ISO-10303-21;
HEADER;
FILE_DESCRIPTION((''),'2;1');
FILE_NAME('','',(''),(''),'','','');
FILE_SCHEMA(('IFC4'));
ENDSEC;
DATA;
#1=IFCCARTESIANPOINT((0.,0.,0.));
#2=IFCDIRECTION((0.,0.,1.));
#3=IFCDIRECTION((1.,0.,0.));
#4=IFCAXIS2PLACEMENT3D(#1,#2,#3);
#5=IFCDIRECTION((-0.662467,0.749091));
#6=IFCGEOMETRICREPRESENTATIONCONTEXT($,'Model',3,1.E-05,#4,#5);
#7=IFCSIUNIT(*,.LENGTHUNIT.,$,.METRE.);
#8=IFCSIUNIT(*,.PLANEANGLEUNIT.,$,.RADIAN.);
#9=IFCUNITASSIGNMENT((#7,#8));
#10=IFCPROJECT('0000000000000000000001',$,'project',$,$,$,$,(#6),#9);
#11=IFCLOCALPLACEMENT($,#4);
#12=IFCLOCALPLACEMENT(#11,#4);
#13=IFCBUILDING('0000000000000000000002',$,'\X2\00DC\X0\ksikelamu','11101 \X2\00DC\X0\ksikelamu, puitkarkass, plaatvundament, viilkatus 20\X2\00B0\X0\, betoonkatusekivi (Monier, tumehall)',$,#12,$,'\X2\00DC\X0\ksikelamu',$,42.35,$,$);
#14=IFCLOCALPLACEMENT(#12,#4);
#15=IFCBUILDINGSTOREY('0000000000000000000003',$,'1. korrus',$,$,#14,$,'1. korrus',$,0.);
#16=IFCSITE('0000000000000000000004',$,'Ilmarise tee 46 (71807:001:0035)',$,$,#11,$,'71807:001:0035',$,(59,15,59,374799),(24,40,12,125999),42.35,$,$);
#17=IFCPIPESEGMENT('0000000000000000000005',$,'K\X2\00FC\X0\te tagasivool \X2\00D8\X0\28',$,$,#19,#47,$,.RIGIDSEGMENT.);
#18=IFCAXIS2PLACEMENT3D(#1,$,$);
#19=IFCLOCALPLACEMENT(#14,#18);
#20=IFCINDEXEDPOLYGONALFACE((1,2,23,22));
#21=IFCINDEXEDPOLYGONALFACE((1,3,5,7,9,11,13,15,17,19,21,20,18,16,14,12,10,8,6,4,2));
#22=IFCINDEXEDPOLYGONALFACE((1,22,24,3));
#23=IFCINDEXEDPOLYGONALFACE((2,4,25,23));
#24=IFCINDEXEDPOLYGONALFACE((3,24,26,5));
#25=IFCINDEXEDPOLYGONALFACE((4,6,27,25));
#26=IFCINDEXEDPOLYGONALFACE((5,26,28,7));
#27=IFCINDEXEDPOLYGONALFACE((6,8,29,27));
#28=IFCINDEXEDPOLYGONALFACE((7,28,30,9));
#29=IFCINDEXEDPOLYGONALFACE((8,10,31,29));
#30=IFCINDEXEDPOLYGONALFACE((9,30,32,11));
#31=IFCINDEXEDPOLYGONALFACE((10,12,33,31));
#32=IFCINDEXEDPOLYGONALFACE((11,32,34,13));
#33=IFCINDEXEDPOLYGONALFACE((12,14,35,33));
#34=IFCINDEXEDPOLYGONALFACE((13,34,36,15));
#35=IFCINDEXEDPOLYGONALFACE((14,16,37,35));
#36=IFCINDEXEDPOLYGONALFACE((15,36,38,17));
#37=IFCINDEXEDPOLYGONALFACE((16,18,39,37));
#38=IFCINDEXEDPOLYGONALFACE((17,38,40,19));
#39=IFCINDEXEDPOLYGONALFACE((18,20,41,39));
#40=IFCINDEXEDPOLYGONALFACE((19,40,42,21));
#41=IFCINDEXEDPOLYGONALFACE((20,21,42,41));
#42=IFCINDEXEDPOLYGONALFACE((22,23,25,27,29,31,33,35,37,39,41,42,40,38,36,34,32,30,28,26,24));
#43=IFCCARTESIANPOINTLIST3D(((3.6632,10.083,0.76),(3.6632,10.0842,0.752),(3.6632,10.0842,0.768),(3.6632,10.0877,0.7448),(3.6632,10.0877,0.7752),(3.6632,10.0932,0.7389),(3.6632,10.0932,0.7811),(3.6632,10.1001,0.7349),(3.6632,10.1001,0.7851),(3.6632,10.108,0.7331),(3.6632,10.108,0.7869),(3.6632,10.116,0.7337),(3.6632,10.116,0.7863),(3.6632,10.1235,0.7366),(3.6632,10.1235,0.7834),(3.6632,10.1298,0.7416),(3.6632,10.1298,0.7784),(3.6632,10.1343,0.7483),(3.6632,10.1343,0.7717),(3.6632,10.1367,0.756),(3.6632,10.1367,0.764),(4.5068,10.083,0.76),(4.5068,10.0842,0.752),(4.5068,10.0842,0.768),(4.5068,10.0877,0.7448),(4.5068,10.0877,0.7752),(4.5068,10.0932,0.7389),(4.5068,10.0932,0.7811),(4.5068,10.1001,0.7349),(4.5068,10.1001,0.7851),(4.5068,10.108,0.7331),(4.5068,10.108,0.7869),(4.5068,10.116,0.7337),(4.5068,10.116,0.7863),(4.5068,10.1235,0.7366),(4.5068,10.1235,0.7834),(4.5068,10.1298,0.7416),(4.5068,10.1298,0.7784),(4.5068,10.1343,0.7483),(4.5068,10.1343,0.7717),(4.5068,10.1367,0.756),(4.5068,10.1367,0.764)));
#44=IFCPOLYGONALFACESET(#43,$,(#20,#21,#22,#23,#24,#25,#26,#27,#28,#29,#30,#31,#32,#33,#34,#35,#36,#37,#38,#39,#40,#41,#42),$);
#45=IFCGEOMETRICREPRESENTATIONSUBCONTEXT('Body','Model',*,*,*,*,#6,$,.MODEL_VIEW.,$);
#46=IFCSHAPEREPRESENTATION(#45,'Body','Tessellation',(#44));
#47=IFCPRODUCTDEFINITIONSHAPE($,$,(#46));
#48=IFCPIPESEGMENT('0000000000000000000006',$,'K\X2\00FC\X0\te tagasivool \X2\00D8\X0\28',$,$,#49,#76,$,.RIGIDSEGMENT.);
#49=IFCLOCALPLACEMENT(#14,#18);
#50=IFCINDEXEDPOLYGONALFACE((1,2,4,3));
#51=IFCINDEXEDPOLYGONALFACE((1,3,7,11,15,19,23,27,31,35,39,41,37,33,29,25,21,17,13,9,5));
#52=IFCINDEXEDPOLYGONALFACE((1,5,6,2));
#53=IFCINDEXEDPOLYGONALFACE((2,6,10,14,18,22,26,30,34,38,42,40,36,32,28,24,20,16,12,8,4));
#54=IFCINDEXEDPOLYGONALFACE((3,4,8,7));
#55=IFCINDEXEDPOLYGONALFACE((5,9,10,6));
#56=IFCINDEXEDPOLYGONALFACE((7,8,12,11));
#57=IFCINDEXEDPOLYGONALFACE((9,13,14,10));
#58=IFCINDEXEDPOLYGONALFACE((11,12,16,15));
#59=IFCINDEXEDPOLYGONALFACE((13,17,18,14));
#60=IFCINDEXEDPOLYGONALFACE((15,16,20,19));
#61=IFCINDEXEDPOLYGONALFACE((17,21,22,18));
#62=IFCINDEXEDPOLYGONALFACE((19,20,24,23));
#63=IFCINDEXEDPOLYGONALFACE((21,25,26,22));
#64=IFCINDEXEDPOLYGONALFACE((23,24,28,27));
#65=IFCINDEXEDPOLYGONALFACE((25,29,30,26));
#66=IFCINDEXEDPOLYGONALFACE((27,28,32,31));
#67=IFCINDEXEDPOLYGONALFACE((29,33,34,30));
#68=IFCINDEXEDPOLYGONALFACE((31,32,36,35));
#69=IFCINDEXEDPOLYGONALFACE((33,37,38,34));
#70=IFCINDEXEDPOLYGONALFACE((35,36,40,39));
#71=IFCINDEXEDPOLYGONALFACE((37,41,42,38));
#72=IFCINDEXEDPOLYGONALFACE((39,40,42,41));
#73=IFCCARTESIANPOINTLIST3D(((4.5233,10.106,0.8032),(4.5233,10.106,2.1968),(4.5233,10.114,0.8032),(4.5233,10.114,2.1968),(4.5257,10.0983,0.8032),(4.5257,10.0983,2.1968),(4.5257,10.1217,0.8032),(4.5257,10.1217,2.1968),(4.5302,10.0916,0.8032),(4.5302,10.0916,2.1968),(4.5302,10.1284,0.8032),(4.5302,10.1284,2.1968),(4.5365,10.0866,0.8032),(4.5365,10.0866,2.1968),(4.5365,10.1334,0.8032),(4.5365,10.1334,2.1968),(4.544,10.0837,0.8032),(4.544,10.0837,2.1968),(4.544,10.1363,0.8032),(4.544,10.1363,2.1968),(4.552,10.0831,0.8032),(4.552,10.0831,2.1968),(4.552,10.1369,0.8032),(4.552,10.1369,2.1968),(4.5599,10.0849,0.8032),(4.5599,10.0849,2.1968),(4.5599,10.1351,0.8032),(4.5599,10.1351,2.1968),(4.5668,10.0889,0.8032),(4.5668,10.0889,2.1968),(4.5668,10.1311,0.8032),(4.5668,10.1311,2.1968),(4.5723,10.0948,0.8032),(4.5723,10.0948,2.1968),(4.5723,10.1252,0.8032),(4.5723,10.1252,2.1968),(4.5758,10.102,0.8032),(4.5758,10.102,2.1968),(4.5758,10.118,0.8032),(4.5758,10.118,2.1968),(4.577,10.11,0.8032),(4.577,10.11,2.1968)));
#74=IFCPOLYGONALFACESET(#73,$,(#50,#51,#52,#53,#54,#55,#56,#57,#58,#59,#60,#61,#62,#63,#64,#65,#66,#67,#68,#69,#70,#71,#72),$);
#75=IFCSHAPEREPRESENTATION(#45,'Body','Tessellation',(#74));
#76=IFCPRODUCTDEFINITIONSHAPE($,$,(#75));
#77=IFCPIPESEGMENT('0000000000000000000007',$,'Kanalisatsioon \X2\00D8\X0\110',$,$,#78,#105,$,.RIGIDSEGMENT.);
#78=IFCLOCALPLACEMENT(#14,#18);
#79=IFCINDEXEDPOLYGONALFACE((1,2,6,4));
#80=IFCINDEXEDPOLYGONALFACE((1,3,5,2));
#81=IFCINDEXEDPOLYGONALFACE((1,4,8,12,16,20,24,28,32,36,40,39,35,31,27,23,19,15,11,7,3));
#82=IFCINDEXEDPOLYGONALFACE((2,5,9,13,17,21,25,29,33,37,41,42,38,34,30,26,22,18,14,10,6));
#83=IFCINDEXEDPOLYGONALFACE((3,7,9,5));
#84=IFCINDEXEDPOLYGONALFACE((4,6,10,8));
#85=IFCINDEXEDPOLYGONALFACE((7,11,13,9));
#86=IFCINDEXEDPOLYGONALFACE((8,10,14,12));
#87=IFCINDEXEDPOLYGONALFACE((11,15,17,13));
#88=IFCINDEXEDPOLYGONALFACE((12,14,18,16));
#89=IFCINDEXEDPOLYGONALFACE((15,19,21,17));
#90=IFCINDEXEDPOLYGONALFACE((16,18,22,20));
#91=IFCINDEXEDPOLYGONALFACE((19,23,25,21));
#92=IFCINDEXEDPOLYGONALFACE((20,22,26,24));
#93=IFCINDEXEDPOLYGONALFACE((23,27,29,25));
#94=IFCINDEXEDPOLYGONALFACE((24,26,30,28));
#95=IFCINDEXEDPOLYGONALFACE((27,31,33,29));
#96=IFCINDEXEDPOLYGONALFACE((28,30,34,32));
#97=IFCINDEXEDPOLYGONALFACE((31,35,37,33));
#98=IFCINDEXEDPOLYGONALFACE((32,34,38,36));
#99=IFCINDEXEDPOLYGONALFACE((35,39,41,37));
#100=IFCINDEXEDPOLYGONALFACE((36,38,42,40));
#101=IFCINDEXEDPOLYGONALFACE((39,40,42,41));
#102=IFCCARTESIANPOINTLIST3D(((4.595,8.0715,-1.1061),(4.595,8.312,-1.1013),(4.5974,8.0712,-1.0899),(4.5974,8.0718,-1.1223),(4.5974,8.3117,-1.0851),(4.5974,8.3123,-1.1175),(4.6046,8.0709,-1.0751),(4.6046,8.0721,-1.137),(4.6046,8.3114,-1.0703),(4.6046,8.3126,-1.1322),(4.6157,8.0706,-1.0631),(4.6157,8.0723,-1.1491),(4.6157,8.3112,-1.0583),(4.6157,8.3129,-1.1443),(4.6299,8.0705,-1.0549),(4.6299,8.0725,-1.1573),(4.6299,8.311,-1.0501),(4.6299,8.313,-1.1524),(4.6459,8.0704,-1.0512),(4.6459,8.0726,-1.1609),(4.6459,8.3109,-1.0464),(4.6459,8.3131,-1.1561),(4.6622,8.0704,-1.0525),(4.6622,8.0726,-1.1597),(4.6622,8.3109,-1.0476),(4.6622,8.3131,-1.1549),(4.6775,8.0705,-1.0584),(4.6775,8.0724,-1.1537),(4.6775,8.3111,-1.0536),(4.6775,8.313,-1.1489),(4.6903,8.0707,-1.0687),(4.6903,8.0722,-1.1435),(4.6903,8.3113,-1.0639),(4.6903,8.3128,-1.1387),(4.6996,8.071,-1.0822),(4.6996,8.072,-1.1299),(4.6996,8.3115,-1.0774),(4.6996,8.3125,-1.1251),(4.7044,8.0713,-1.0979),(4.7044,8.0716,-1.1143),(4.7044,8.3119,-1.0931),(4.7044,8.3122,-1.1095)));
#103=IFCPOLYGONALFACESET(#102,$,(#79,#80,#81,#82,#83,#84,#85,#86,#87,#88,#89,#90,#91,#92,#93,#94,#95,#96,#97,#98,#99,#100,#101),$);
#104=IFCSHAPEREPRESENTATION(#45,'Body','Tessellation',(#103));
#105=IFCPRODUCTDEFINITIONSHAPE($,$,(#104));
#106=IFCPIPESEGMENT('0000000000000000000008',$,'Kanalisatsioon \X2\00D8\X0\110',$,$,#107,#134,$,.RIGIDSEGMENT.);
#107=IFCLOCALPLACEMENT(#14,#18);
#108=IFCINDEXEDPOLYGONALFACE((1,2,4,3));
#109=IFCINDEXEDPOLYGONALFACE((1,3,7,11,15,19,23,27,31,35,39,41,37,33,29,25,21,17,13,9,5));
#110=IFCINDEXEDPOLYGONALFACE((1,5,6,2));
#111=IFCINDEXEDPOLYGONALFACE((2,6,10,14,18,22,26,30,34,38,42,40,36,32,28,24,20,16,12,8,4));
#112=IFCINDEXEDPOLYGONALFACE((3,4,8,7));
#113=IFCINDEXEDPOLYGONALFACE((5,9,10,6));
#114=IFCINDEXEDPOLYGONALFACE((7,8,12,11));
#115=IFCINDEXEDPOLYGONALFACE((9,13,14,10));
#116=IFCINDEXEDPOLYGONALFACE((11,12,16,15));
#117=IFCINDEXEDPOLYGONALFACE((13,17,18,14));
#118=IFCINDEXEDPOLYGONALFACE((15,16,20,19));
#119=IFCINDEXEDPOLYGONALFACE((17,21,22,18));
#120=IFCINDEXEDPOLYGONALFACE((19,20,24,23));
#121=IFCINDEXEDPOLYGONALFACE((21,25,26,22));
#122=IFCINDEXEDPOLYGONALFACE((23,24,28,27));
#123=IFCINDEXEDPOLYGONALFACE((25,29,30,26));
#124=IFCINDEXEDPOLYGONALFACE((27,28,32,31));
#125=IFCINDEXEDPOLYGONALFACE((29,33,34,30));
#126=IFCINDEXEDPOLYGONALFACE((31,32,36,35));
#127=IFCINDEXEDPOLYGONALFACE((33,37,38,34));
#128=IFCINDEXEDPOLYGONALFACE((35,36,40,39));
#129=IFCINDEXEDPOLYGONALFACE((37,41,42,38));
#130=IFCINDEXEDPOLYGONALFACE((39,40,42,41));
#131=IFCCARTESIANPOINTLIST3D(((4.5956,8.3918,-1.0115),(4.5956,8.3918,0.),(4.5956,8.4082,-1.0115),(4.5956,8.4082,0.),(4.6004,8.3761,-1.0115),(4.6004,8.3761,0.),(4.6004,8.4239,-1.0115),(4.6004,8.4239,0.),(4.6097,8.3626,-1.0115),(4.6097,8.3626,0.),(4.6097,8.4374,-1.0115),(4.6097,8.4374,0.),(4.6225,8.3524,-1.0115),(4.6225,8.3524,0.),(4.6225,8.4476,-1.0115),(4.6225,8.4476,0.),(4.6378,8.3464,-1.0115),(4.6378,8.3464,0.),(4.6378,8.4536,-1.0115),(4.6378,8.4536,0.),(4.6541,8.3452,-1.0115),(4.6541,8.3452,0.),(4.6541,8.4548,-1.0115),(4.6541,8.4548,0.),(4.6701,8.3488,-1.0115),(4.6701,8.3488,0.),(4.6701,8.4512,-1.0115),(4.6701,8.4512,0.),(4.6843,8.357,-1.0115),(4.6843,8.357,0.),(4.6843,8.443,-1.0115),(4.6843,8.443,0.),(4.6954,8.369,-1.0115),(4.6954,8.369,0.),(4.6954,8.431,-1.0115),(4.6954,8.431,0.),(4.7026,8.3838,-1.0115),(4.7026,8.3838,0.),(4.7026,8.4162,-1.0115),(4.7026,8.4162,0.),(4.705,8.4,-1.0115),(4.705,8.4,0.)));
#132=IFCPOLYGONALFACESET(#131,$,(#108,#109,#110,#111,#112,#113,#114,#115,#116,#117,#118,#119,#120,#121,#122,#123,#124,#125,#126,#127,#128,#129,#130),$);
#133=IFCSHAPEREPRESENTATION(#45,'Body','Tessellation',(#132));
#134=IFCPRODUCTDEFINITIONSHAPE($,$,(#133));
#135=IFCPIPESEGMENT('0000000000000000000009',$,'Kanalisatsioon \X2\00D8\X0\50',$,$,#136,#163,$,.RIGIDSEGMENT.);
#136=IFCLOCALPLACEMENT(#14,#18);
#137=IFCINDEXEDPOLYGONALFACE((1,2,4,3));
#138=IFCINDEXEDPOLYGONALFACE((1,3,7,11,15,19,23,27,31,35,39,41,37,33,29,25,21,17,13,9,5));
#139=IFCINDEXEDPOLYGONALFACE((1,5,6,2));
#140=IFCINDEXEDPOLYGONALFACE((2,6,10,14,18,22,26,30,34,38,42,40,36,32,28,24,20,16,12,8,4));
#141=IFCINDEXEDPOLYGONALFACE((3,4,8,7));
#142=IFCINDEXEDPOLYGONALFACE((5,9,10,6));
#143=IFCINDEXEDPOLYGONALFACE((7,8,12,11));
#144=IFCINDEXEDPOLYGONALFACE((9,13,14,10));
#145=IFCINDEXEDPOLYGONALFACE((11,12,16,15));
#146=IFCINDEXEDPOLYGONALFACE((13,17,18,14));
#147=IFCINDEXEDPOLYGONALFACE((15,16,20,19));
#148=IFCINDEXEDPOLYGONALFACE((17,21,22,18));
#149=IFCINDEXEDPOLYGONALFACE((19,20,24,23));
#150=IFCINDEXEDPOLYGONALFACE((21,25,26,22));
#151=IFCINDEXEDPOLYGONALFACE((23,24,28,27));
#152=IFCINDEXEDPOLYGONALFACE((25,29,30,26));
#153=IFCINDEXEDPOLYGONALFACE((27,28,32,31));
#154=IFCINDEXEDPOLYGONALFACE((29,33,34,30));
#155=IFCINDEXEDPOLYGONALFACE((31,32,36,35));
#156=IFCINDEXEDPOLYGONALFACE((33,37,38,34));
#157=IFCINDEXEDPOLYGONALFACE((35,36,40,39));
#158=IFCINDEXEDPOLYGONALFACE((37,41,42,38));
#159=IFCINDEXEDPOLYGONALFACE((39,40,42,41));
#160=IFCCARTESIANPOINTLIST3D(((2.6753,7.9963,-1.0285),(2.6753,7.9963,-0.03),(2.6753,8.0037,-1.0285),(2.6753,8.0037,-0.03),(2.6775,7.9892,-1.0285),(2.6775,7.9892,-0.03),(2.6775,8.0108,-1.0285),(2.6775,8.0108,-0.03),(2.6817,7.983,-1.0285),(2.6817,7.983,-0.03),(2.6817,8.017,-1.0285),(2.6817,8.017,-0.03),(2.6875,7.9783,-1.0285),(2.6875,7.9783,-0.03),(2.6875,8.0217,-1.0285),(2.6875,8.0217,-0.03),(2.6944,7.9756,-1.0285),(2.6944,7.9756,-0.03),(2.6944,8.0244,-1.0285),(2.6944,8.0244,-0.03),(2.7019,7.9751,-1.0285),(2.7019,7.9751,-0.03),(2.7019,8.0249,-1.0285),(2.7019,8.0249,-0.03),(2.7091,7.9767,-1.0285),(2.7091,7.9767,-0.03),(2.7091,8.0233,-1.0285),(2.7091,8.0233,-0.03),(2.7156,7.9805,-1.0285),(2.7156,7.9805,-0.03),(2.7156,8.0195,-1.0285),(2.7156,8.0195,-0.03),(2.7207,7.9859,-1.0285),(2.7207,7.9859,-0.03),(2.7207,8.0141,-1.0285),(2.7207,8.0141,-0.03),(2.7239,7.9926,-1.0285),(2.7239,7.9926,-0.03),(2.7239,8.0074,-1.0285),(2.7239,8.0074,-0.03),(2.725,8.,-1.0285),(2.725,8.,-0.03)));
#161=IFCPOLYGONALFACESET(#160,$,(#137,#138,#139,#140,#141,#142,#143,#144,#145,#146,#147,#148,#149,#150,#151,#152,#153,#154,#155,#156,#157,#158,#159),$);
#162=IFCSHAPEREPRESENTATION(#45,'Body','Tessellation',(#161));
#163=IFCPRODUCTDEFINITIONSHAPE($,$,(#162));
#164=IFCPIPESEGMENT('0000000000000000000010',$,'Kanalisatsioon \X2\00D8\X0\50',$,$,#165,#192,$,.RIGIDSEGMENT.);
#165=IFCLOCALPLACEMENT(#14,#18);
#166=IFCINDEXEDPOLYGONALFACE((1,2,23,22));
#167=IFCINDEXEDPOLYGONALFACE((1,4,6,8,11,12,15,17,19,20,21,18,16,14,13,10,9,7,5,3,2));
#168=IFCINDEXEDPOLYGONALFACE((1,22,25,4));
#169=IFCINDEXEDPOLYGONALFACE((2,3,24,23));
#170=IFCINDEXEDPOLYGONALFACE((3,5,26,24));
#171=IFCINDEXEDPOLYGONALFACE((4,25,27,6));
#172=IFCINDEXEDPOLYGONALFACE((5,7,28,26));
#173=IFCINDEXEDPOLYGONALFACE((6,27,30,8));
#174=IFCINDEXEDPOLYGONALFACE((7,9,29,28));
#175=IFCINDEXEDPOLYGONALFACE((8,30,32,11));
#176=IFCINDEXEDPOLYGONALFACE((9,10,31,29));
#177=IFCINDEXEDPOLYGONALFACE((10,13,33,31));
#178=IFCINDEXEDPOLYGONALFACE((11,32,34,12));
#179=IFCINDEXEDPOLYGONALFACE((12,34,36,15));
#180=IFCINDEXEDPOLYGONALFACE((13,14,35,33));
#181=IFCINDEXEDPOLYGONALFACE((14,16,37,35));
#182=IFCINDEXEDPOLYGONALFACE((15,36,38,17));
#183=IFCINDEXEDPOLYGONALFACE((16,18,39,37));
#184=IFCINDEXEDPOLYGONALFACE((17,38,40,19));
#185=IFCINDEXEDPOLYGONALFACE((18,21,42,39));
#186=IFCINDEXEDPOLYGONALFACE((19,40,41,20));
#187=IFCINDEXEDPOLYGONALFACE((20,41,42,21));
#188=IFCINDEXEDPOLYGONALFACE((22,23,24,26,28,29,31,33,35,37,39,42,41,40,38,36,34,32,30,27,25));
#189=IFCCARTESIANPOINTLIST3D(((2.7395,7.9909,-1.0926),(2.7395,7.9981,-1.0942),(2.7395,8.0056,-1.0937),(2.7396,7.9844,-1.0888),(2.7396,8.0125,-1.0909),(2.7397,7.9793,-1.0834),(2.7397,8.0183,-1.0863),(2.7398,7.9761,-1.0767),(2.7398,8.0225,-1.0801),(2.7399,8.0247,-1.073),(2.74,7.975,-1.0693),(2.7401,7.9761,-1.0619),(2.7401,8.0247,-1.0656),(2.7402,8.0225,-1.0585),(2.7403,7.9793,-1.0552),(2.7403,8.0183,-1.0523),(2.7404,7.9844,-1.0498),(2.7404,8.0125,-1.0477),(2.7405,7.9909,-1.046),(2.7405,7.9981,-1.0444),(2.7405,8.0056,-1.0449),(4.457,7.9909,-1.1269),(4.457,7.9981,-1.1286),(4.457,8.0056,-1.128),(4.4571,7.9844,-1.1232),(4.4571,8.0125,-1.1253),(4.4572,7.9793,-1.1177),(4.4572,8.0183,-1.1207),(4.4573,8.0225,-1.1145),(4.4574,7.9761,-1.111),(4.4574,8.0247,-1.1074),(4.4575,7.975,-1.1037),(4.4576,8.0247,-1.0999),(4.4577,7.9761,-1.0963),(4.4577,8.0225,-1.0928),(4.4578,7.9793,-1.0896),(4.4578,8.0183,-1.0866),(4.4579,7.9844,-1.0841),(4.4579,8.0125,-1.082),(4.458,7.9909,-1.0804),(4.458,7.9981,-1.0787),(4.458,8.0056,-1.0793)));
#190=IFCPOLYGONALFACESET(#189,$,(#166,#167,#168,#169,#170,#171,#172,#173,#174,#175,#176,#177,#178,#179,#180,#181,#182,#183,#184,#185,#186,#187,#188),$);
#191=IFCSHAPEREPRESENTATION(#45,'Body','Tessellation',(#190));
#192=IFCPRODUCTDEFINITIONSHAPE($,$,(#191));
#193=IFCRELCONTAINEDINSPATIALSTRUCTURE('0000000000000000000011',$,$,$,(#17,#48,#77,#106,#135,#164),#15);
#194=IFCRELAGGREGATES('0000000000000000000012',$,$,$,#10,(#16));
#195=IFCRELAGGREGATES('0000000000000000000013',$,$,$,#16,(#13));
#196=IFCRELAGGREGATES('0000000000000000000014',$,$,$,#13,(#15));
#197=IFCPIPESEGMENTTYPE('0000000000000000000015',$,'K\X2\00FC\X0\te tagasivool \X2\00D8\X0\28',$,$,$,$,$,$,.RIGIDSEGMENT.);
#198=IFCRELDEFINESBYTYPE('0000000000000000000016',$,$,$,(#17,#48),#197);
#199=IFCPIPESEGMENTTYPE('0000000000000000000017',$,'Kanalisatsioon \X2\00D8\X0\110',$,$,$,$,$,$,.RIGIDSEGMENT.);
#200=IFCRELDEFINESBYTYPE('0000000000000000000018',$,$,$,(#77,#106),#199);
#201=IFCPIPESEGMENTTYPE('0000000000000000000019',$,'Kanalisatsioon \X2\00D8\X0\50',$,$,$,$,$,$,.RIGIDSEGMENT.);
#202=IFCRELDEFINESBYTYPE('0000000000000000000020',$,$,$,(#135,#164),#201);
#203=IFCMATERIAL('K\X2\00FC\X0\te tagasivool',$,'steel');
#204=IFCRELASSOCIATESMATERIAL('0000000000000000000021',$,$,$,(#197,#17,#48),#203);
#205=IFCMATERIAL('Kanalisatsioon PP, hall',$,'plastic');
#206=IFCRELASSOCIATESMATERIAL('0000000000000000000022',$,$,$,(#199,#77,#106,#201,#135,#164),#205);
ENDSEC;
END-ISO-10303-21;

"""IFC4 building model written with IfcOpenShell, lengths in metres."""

from ifc_helpers import new_model, si_unit, direction, frame, origin_with_axes, place, context, subcontext, project, spatial, circle, extrude, material, type_object, element, save


model = new_model("IFC4")

# Units and contexts
model_context = context("Model", 3, precision=1e-05, world=origin_with_axes(), true_north=direction((-0.662467, 0.749091)))
body_context = subcontext(model_context, "Body", "Model", "MODEL_VIEW")
ifc_project = project(units=[si_unit("LENGTHUNIT", "METRE"), si_unit("PLANEANGLEUNIT", "RADIAN")], contexts=[model_context])

# Site, building, storey
site_placement = place(None, origin_with_axes())
site = spatial("IfcSite", under=ifc_project, at=site_placement, Name="Ilmarise tee 46 (71807:001:0035)", LongName="71807:001:0035", RefLatitude=(59, 15, 59, 374799), RefLongitude=(24, 40, 12, 125999), RefElevation=42.35)
building_placement = place(site_placement, origin_with_axes())
building = spatial("IfcBuilding", under=site, at=building_placement, Name="Üksikelamu", Description="11101 Üksikelamu, puitkarkass, plaatvundament, viilkatus 20°, betoonkatusekivi (Monier, tumehall)", LongName="Üksikelamu", ElevationOfRefHeight=42.35)
storey_placement = place(building_placement, origin_with_axes())
storey = spatial("IfcBuildingStorey", under=building, at=storey_placement, Name="1. korrus", LongName="1. korrus", Elevation=0.0)

# Shared definitions
ifc_material_1 = material(Name="Küte tagasivool", Category="steel")
ifc_material_2 = material(Name="Kanalisatsioon PP, hall", Category="plastic")

# Pipe segments
pipe_segment_type_1 = type_object("IfcPipeSegmentType", Name="Küte tagasivool Ø28", PredefinedType="RIGIDSEGMENT", material=ifc_material_1)
pipe_segment_1_placement = place(storey_placement, frame((3.6632, 10.11, 0.76), z_axis=(1.0, 0.0, 0.0), x_axis=(0.0, -1.0, 0.0)))
element("IfcPipeSegment", 1, at=pipe_segment_1_placement, inside=storey, type_object=pipe_segment_type_1, material=ifc_material_1, Name="Küte tagasivool Ø28", PredefinedType="RIGIDSEGMENT", context=body_context, shape_type="SweptSolid", body=[
    extrude(circle(Radius=0.027), origin_with_axes(), (0.0, 0.0, 1.0), 0.8436),
])
pipe_segment_2_placement = place(storey_placement, frame((4.55, 10.11, 0.8032), z_axis=(0.0, 0.0, 1.0), x_axis=(1.0, 0.0, 0.0)))
element("IfcPipeSegment", 2, at=pipe_segment_2_placement, inside=storey, type_object=pipe_segment_type_1, material=ifc_material_1, Name="Küte tagasivool Ø28", PredefinedType="RIGIDSEGMENT", context=body_context, shape_type="SweptSolid", body=[
    extrude(circle(Radius=0.027), origin_with_axes(), (0.0, 0.0, 1.0), 1.3936),
])
pipe_segment_type_2 = type_object("IfcPipeSegmentType", Name="Kanalisatsioon Ø110", PredefinedType="RIGIDSEGMENT", material=ifc_material_2)
pipe_segment_3_placement = place(storey_placement, frame((4.65, 8.312, -1.1013), z_axis=(0.0, -0.9998, -0.019996), x_axis=(-1.0, 0.0, 0.0)))
element("IfcPipeSegment", 3, at=pipe_segment_3_placement, inside=storey, type_object=pipe_segment_type_2, material=ifc_material_2, Name="Kanalisatsioon Ø110", PredefinedType="RIGIDSEGMENT", context=body_context, shape_type="SweptSolid", body=[
    extrude(circle(Radius=0.055), origin_with_axes(), (0.0, 0.0, 1.0), 0.2406),
])
pipe_segment_4_placement = place(storey_placement, frame((4.65, 8.4, 0.0), z_axis=(0.0, 0.0, -1.0), x_axis=(1.0, 0.0, 0.0)))
element("IfcPipeSegment", 4, at=pipe_segment_4_placement, inside=storey, type_object=pipe_segment_type_2, material=ifc_material_2, Name="Kanalisatsioon Ø110", PredefinedType="RIGIDSEGMENT", context=body_context, shape_type="SweptSolid", body=[
    extrude(circle(Radius=0.055), origin_with_axes(), (0.0, 0.0, 1.0), 1.0115),
])
pipe_segment_type_3 = type_object("IfcPipeSegmentType", Name="Kanalisatsioon Ø50", PredefinedType="RIGIDSEGMENT", material=ifc_material_2)
pipe_segment_5_placement = place(storey_placement, frame((2.7, 8.0, -0.03), z_axis=(0.0, 0.0, -1.0), x_axis=(1.0, 0.0, 0.0)))
element("IfcPipeSegment", 5, at=pipe_segment_5_placement, inside=storey, type_object=pipe_segment_type_3, material=ifc_material_2, Name="Kanalisatsioon Ø50", PredefinedType="RIGIDSEGMENT", context=body_context, shape_type="SweptSolid", body=[
    extrude(circle(Radius=0.025), origin_with_axes(), (0.0, 0.0, 1.0), 0.9985),
])
pipe_segment_6_placement = place(storey_placement, frame((2.74, 8.0, -1.0693), z_axis=(0.9998, 0.0, -0.019996), x_axis=(0.0, -1.0, 0.0)))
element("IfcPipeSegment", 6, at=pipe_segment_6_placement, inside=storey, type_object=pipe_segment_type_3, material=ifc_material_2, Name="Kanalisatsioon Ø50", PredefinedType="RIGIDSEGMENT", context=body_context, shape_type="SweptSolid", body=[
    extrude(circle(Radius=0.025), origin_with_axes(), (0.0, 0.0, 1.0), 1.7179),
])

save(model, "model.ifc")
